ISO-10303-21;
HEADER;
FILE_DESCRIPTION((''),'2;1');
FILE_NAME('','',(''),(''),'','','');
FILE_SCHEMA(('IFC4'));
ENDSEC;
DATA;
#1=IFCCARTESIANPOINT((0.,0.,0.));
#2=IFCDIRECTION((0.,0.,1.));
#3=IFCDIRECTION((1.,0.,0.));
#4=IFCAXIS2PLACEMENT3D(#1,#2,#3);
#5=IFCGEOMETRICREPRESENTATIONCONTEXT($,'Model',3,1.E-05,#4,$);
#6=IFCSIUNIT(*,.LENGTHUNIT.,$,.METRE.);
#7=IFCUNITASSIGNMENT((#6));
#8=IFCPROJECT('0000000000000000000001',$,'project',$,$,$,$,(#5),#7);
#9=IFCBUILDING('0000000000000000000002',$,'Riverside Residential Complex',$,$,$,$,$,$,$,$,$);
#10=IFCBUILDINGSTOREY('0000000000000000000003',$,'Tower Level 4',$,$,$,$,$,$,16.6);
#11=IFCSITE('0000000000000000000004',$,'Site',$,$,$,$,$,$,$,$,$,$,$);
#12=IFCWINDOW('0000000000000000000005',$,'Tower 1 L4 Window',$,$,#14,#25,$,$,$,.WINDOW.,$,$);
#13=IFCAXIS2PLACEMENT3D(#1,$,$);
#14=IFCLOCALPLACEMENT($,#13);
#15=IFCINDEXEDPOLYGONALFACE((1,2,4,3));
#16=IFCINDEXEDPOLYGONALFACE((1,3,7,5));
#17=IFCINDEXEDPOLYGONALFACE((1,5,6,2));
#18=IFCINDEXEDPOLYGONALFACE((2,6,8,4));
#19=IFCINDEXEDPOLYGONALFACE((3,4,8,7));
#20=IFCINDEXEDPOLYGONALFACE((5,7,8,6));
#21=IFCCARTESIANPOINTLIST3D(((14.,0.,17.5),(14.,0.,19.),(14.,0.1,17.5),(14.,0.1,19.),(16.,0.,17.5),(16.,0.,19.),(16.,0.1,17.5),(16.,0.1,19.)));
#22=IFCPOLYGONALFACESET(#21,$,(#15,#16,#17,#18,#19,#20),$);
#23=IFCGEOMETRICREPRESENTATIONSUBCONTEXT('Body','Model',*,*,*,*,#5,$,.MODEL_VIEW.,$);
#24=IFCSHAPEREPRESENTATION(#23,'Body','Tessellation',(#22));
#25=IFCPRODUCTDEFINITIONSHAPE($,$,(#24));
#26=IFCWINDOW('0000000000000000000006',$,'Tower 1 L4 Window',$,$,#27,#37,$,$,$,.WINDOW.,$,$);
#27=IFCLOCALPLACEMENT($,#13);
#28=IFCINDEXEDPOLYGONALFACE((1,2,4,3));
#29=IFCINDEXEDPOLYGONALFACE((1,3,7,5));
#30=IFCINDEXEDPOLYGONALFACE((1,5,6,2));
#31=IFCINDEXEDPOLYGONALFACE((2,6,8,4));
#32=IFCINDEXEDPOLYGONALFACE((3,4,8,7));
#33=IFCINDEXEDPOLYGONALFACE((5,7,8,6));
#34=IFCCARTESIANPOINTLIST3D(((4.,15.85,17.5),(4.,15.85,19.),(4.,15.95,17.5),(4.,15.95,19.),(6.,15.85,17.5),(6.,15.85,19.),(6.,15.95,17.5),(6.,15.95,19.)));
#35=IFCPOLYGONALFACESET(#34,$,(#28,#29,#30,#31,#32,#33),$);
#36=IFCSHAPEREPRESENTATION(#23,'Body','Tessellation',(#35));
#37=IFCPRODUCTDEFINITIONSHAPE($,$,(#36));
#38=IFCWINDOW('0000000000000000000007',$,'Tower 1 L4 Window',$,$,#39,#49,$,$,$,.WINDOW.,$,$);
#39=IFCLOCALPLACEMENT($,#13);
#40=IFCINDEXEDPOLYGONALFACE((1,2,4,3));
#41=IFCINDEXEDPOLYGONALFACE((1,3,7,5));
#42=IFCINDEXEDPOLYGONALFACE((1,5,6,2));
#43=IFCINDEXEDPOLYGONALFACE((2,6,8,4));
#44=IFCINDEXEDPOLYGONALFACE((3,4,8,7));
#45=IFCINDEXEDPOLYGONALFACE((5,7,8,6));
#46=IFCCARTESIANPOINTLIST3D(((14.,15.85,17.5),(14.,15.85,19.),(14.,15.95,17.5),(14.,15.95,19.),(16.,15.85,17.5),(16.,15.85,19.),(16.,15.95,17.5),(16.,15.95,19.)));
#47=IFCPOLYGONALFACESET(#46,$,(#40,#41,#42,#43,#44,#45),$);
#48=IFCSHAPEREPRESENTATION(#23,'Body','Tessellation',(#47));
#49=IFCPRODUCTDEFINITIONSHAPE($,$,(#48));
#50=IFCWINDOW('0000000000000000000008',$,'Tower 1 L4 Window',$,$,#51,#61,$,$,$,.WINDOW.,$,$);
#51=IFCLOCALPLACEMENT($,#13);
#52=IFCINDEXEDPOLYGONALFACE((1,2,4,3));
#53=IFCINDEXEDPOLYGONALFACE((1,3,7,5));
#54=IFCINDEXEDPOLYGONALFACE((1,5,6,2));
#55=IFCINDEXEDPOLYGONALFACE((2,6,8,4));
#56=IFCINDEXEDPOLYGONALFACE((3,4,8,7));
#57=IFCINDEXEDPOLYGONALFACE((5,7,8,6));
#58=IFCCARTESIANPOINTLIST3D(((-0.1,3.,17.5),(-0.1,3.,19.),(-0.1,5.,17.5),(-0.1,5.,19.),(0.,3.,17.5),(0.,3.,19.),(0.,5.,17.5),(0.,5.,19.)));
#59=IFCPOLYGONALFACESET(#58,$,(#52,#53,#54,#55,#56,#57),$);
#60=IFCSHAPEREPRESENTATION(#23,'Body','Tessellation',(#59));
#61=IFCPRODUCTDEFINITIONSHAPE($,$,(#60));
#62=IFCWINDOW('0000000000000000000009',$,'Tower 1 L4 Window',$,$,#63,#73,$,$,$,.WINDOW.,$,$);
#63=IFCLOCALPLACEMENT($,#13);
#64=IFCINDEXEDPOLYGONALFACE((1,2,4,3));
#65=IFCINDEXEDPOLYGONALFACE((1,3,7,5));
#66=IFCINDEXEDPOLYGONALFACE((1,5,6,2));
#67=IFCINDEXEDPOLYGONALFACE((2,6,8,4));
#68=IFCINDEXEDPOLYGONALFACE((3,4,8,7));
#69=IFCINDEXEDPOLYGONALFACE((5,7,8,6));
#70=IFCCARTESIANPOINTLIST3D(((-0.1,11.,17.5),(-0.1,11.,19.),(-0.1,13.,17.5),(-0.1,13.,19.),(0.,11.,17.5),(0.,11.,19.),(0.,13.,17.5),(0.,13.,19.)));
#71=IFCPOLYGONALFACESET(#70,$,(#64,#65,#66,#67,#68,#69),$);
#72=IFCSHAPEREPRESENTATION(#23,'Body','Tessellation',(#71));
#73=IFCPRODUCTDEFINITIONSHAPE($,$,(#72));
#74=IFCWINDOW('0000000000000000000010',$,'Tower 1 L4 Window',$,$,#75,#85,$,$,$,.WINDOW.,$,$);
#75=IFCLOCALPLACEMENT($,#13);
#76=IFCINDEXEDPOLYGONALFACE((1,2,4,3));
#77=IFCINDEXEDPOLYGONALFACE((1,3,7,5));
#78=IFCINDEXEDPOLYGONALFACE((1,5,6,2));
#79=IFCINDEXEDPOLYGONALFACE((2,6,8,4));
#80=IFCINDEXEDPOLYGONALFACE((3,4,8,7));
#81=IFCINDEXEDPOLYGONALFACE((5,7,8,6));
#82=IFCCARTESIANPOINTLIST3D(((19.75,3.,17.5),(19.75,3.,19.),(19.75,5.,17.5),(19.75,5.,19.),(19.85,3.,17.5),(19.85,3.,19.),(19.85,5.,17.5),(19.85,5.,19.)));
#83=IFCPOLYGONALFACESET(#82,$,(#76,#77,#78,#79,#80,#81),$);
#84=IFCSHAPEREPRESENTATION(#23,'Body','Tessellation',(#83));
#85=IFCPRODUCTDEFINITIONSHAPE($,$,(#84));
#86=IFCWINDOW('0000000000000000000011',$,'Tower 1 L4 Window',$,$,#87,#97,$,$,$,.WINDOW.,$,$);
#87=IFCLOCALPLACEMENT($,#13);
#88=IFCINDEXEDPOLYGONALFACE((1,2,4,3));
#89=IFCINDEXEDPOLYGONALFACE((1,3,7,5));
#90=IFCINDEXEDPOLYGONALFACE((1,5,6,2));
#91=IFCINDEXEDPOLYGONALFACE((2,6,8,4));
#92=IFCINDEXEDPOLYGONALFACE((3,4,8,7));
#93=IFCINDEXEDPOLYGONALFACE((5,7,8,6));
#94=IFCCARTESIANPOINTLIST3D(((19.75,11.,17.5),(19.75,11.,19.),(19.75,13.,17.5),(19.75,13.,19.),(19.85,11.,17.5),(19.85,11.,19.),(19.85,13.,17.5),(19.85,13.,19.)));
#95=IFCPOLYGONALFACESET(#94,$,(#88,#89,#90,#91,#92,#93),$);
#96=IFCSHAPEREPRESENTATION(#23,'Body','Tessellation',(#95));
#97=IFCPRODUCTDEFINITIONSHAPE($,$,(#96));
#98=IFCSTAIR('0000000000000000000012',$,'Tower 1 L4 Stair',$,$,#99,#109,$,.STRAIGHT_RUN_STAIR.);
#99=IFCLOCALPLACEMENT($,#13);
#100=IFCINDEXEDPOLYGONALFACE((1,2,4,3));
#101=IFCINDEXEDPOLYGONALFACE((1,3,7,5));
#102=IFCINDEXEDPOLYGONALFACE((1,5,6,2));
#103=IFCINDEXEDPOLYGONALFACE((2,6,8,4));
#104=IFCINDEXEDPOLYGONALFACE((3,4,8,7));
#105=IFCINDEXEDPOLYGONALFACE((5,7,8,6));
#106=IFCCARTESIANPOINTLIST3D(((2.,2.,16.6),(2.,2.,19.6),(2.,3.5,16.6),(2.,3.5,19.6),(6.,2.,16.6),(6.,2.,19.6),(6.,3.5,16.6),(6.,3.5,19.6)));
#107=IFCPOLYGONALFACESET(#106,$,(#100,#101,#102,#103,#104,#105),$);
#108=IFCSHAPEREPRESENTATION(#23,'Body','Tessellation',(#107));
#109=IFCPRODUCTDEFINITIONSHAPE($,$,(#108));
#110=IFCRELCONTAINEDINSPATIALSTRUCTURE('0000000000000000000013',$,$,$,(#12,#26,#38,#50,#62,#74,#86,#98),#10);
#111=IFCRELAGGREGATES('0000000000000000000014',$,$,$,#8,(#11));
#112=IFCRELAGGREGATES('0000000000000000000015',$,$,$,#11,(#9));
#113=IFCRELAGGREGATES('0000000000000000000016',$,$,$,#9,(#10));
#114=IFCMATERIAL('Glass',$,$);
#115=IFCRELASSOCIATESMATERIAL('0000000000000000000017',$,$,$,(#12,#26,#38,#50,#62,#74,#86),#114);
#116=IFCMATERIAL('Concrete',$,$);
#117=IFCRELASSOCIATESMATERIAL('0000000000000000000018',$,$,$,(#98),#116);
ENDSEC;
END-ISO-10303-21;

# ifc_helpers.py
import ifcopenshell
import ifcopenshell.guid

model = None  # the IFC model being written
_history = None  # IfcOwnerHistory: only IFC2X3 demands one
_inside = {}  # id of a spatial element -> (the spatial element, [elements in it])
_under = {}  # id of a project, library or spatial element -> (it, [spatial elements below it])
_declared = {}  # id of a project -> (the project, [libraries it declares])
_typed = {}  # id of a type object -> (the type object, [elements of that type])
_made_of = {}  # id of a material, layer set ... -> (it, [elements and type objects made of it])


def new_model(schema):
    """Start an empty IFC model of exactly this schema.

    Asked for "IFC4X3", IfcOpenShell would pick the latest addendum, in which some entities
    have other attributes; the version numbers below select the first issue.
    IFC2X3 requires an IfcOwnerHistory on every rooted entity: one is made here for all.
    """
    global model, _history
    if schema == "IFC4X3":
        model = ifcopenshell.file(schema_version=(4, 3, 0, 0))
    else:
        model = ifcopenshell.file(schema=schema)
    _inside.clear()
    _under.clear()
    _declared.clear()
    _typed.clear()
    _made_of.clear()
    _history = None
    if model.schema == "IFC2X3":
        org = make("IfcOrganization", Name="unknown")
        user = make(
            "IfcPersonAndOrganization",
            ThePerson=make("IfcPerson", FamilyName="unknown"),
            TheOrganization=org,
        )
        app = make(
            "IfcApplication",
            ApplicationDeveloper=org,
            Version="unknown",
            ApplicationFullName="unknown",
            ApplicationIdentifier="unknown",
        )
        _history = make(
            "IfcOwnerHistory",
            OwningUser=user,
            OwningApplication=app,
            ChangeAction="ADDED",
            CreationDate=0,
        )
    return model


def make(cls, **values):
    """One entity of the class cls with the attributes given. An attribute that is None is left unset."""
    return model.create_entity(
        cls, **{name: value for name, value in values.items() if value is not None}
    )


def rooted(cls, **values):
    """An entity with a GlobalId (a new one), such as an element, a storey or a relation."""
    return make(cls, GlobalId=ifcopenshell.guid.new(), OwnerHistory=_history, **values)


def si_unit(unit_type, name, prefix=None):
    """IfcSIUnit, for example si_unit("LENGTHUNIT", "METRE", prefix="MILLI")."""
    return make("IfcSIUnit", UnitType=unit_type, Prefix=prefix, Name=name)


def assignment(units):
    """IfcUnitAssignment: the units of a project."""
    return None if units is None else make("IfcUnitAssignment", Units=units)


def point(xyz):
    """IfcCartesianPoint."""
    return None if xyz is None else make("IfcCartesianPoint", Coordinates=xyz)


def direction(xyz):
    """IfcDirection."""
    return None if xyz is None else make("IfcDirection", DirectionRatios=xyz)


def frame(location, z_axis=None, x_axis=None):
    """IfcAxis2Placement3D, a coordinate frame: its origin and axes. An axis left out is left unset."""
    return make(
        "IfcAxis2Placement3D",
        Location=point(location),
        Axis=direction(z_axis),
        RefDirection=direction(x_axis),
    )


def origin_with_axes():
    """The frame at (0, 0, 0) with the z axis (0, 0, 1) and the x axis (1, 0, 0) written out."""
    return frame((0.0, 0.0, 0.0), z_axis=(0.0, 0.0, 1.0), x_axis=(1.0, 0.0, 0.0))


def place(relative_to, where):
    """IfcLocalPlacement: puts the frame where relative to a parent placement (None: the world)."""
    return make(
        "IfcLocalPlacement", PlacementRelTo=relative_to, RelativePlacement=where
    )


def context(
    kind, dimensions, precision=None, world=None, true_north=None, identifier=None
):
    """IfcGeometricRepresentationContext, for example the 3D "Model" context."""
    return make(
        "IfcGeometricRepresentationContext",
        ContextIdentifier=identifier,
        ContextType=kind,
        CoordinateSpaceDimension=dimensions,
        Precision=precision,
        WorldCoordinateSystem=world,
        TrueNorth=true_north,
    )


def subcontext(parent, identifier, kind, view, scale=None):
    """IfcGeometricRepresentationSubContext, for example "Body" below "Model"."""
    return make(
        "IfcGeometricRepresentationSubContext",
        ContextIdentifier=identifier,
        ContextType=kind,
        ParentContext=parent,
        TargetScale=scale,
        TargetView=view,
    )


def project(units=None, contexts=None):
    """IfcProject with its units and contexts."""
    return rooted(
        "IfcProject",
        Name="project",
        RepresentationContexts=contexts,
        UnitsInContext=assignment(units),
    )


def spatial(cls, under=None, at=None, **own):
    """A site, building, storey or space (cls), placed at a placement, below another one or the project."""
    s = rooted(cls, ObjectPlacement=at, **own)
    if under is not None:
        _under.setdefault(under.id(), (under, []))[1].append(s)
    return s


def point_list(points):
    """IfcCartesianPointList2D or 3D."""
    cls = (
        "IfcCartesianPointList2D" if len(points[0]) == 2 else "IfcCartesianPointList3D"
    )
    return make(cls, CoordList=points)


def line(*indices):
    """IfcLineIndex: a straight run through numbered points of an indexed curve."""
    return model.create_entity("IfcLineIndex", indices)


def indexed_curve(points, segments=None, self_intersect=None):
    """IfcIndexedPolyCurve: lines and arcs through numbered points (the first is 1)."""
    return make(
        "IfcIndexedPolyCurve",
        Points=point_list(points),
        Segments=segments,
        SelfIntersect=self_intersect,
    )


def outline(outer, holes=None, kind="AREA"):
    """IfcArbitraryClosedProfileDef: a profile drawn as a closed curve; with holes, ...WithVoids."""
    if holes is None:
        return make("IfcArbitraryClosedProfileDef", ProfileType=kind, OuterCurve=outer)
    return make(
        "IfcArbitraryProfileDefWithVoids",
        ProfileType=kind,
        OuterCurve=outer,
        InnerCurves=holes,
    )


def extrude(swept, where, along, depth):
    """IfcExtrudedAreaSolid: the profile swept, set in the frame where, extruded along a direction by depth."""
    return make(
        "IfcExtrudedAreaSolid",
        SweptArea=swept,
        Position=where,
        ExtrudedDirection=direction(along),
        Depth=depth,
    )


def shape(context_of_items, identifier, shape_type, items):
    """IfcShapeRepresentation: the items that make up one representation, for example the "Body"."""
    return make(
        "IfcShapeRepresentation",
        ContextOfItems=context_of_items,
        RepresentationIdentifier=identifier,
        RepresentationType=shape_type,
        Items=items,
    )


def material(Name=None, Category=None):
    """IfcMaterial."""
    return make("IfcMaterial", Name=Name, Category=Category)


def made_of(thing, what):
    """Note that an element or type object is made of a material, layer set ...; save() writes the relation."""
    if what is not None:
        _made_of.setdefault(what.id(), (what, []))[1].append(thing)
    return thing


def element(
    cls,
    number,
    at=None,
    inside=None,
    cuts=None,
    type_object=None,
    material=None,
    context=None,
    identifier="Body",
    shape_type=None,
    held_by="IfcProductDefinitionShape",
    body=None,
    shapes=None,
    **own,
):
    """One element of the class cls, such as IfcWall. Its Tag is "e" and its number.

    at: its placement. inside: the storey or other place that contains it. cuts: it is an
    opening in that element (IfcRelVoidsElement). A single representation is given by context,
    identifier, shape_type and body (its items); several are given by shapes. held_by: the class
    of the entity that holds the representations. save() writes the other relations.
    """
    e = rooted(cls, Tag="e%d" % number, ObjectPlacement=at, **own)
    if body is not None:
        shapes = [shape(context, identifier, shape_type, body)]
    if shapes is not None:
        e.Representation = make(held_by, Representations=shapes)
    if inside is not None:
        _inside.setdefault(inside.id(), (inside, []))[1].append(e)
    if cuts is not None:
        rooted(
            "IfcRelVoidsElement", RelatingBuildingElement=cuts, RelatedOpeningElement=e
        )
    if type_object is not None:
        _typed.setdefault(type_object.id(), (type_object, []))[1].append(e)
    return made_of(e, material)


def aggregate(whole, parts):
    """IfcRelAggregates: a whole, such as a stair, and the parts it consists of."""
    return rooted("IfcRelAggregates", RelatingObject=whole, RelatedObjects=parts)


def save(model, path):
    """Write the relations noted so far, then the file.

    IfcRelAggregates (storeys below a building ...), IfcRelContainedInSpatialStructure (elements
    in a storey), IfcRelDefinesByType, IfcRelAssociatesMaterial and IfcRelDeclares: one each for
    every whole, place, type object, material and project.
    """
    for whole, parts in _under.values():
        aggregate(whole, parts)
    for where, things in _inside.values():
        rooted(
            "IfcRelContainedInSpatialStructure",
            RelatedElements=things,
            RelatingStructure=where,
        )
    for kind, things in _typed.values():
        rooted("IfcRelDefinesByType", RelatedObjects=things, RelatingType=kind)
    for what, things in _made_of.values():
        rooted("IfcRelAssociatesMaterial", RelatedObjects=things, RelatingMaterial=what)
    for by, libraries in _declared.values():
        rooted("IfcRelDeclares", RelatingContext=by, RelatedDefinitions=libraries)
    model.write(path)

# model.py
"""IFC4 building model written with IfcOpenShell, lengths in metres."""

from ifc_helpers import new_model, si_unit, frame, origin_with_axes, place, context, subcontext, project, spatial, line, indexed_curve, outline, extrude, material, element, save


model = new_model("IFC4")

# Units and contexts
model_context = context("Model", 3, precision=1e-05, world=origin_with_axes())
body_context = subcontext(model_context, "Body", "Model", "MODEL_VIEW")
ifc_project = project(units=[si_unit("LENGTHUNIT", "METRE")], contexts=[model_context])

# Site, building, storey
site = spatial("IfcSite", under=ifc_project, Name="Site")
building = spatial("IfcBuilding", under=site, Name="Riverside Residential Complex")
storey = spatial("IfcBuildingStorey", under=building, Name="Tower Level 4", Elevation=16.6)

# Shared definitions
ifc_material_1 = material(Name="Concrete")

# Windows
ifc_material_2 = material(Name="Glass")
for number, where, z_axis, x_axis, name in (
    (1, (14.0, 0.0, 17.5), (0.0, 0.0, 1.0), (1.0, 0.0, 0.0), "Tower 1 L4 Window"),
    (2, (4.0, 15.85, 17.5), (0.0, 0.0, 1.0), (1.0, 0.0, 0.0), "Tower 1 L4 Window"),
    (3, (14.0, 15.85, 17.5), (0.0, 0.0, 1.0), (1.0, 0.0, 0.0), "Tower 1 L4 Window"),
    (4, (0.0, 3.0, 17.5), (0.0, 0.0, 1.0), (0.0, 1.0, 0.0), "Tower 1 L4 Window"),
    (5, (0.0, 11.0, 17.5), (0.0, 0.0, 1.0), (0.0, 1.0, 0.0), "Tower 1 L4 Window"),
    (6, (19.85, 3.0, 17.5), (0.0, 0.0, 1.0), (0.0, 1.0, 0.0), "Tower 1 L4 Window"),
    (7, (19.85, 11.0, 17.5), (0.0, 0.0, 1.0), (0.0, 1.0, 0.0), "Tower 1 L4 Window"),
):
    element("IfcWindow", number, at=place(None, frame(where, z_axis=z_axis, x_axis=x_axis)), inside=storey, material=ifc_material_2, Name=name, PredefinedType="WINDOW", context=body_context, shape_type="SweptSolid", body=[
        extrude(outline(indexed_curve([(0.0, 0.0), (2.0, 0.0), (2.0, 0.1), (0.0, 0.1)], segments=[line(1, 2, 3, 4, 1)])), origin_with_axes(), (0.0, 0.0, 1.0), 1.5),
    ])

# Stair
stair_placement = place(None, frame((2.0, 2.0, 16.6), z_axis=(0.0, 0.0, 1.0), x_axis=(1.0, 0.0, 0.0)))
element("IfcStair", 8, at=stair_placement, inside=storey, material=ifc_material_1, Name="Tower 1 L4 Stair", PredefinedType="STRAIGHT_RUN_STAIR", context=body_context, shape_type="SweptSolid", body=[
    extrude(outline(indexed_curve([(0.0, 0.0), (4.0, 0.0), (4.0, 1.5), (0.0, 1.5)], segments=[line(1, 2, 3, 4, 1)])), origin_with_axes(), (0.0, 0.0, 1.0), 3.0),
])

save(model, "model.ifc")
